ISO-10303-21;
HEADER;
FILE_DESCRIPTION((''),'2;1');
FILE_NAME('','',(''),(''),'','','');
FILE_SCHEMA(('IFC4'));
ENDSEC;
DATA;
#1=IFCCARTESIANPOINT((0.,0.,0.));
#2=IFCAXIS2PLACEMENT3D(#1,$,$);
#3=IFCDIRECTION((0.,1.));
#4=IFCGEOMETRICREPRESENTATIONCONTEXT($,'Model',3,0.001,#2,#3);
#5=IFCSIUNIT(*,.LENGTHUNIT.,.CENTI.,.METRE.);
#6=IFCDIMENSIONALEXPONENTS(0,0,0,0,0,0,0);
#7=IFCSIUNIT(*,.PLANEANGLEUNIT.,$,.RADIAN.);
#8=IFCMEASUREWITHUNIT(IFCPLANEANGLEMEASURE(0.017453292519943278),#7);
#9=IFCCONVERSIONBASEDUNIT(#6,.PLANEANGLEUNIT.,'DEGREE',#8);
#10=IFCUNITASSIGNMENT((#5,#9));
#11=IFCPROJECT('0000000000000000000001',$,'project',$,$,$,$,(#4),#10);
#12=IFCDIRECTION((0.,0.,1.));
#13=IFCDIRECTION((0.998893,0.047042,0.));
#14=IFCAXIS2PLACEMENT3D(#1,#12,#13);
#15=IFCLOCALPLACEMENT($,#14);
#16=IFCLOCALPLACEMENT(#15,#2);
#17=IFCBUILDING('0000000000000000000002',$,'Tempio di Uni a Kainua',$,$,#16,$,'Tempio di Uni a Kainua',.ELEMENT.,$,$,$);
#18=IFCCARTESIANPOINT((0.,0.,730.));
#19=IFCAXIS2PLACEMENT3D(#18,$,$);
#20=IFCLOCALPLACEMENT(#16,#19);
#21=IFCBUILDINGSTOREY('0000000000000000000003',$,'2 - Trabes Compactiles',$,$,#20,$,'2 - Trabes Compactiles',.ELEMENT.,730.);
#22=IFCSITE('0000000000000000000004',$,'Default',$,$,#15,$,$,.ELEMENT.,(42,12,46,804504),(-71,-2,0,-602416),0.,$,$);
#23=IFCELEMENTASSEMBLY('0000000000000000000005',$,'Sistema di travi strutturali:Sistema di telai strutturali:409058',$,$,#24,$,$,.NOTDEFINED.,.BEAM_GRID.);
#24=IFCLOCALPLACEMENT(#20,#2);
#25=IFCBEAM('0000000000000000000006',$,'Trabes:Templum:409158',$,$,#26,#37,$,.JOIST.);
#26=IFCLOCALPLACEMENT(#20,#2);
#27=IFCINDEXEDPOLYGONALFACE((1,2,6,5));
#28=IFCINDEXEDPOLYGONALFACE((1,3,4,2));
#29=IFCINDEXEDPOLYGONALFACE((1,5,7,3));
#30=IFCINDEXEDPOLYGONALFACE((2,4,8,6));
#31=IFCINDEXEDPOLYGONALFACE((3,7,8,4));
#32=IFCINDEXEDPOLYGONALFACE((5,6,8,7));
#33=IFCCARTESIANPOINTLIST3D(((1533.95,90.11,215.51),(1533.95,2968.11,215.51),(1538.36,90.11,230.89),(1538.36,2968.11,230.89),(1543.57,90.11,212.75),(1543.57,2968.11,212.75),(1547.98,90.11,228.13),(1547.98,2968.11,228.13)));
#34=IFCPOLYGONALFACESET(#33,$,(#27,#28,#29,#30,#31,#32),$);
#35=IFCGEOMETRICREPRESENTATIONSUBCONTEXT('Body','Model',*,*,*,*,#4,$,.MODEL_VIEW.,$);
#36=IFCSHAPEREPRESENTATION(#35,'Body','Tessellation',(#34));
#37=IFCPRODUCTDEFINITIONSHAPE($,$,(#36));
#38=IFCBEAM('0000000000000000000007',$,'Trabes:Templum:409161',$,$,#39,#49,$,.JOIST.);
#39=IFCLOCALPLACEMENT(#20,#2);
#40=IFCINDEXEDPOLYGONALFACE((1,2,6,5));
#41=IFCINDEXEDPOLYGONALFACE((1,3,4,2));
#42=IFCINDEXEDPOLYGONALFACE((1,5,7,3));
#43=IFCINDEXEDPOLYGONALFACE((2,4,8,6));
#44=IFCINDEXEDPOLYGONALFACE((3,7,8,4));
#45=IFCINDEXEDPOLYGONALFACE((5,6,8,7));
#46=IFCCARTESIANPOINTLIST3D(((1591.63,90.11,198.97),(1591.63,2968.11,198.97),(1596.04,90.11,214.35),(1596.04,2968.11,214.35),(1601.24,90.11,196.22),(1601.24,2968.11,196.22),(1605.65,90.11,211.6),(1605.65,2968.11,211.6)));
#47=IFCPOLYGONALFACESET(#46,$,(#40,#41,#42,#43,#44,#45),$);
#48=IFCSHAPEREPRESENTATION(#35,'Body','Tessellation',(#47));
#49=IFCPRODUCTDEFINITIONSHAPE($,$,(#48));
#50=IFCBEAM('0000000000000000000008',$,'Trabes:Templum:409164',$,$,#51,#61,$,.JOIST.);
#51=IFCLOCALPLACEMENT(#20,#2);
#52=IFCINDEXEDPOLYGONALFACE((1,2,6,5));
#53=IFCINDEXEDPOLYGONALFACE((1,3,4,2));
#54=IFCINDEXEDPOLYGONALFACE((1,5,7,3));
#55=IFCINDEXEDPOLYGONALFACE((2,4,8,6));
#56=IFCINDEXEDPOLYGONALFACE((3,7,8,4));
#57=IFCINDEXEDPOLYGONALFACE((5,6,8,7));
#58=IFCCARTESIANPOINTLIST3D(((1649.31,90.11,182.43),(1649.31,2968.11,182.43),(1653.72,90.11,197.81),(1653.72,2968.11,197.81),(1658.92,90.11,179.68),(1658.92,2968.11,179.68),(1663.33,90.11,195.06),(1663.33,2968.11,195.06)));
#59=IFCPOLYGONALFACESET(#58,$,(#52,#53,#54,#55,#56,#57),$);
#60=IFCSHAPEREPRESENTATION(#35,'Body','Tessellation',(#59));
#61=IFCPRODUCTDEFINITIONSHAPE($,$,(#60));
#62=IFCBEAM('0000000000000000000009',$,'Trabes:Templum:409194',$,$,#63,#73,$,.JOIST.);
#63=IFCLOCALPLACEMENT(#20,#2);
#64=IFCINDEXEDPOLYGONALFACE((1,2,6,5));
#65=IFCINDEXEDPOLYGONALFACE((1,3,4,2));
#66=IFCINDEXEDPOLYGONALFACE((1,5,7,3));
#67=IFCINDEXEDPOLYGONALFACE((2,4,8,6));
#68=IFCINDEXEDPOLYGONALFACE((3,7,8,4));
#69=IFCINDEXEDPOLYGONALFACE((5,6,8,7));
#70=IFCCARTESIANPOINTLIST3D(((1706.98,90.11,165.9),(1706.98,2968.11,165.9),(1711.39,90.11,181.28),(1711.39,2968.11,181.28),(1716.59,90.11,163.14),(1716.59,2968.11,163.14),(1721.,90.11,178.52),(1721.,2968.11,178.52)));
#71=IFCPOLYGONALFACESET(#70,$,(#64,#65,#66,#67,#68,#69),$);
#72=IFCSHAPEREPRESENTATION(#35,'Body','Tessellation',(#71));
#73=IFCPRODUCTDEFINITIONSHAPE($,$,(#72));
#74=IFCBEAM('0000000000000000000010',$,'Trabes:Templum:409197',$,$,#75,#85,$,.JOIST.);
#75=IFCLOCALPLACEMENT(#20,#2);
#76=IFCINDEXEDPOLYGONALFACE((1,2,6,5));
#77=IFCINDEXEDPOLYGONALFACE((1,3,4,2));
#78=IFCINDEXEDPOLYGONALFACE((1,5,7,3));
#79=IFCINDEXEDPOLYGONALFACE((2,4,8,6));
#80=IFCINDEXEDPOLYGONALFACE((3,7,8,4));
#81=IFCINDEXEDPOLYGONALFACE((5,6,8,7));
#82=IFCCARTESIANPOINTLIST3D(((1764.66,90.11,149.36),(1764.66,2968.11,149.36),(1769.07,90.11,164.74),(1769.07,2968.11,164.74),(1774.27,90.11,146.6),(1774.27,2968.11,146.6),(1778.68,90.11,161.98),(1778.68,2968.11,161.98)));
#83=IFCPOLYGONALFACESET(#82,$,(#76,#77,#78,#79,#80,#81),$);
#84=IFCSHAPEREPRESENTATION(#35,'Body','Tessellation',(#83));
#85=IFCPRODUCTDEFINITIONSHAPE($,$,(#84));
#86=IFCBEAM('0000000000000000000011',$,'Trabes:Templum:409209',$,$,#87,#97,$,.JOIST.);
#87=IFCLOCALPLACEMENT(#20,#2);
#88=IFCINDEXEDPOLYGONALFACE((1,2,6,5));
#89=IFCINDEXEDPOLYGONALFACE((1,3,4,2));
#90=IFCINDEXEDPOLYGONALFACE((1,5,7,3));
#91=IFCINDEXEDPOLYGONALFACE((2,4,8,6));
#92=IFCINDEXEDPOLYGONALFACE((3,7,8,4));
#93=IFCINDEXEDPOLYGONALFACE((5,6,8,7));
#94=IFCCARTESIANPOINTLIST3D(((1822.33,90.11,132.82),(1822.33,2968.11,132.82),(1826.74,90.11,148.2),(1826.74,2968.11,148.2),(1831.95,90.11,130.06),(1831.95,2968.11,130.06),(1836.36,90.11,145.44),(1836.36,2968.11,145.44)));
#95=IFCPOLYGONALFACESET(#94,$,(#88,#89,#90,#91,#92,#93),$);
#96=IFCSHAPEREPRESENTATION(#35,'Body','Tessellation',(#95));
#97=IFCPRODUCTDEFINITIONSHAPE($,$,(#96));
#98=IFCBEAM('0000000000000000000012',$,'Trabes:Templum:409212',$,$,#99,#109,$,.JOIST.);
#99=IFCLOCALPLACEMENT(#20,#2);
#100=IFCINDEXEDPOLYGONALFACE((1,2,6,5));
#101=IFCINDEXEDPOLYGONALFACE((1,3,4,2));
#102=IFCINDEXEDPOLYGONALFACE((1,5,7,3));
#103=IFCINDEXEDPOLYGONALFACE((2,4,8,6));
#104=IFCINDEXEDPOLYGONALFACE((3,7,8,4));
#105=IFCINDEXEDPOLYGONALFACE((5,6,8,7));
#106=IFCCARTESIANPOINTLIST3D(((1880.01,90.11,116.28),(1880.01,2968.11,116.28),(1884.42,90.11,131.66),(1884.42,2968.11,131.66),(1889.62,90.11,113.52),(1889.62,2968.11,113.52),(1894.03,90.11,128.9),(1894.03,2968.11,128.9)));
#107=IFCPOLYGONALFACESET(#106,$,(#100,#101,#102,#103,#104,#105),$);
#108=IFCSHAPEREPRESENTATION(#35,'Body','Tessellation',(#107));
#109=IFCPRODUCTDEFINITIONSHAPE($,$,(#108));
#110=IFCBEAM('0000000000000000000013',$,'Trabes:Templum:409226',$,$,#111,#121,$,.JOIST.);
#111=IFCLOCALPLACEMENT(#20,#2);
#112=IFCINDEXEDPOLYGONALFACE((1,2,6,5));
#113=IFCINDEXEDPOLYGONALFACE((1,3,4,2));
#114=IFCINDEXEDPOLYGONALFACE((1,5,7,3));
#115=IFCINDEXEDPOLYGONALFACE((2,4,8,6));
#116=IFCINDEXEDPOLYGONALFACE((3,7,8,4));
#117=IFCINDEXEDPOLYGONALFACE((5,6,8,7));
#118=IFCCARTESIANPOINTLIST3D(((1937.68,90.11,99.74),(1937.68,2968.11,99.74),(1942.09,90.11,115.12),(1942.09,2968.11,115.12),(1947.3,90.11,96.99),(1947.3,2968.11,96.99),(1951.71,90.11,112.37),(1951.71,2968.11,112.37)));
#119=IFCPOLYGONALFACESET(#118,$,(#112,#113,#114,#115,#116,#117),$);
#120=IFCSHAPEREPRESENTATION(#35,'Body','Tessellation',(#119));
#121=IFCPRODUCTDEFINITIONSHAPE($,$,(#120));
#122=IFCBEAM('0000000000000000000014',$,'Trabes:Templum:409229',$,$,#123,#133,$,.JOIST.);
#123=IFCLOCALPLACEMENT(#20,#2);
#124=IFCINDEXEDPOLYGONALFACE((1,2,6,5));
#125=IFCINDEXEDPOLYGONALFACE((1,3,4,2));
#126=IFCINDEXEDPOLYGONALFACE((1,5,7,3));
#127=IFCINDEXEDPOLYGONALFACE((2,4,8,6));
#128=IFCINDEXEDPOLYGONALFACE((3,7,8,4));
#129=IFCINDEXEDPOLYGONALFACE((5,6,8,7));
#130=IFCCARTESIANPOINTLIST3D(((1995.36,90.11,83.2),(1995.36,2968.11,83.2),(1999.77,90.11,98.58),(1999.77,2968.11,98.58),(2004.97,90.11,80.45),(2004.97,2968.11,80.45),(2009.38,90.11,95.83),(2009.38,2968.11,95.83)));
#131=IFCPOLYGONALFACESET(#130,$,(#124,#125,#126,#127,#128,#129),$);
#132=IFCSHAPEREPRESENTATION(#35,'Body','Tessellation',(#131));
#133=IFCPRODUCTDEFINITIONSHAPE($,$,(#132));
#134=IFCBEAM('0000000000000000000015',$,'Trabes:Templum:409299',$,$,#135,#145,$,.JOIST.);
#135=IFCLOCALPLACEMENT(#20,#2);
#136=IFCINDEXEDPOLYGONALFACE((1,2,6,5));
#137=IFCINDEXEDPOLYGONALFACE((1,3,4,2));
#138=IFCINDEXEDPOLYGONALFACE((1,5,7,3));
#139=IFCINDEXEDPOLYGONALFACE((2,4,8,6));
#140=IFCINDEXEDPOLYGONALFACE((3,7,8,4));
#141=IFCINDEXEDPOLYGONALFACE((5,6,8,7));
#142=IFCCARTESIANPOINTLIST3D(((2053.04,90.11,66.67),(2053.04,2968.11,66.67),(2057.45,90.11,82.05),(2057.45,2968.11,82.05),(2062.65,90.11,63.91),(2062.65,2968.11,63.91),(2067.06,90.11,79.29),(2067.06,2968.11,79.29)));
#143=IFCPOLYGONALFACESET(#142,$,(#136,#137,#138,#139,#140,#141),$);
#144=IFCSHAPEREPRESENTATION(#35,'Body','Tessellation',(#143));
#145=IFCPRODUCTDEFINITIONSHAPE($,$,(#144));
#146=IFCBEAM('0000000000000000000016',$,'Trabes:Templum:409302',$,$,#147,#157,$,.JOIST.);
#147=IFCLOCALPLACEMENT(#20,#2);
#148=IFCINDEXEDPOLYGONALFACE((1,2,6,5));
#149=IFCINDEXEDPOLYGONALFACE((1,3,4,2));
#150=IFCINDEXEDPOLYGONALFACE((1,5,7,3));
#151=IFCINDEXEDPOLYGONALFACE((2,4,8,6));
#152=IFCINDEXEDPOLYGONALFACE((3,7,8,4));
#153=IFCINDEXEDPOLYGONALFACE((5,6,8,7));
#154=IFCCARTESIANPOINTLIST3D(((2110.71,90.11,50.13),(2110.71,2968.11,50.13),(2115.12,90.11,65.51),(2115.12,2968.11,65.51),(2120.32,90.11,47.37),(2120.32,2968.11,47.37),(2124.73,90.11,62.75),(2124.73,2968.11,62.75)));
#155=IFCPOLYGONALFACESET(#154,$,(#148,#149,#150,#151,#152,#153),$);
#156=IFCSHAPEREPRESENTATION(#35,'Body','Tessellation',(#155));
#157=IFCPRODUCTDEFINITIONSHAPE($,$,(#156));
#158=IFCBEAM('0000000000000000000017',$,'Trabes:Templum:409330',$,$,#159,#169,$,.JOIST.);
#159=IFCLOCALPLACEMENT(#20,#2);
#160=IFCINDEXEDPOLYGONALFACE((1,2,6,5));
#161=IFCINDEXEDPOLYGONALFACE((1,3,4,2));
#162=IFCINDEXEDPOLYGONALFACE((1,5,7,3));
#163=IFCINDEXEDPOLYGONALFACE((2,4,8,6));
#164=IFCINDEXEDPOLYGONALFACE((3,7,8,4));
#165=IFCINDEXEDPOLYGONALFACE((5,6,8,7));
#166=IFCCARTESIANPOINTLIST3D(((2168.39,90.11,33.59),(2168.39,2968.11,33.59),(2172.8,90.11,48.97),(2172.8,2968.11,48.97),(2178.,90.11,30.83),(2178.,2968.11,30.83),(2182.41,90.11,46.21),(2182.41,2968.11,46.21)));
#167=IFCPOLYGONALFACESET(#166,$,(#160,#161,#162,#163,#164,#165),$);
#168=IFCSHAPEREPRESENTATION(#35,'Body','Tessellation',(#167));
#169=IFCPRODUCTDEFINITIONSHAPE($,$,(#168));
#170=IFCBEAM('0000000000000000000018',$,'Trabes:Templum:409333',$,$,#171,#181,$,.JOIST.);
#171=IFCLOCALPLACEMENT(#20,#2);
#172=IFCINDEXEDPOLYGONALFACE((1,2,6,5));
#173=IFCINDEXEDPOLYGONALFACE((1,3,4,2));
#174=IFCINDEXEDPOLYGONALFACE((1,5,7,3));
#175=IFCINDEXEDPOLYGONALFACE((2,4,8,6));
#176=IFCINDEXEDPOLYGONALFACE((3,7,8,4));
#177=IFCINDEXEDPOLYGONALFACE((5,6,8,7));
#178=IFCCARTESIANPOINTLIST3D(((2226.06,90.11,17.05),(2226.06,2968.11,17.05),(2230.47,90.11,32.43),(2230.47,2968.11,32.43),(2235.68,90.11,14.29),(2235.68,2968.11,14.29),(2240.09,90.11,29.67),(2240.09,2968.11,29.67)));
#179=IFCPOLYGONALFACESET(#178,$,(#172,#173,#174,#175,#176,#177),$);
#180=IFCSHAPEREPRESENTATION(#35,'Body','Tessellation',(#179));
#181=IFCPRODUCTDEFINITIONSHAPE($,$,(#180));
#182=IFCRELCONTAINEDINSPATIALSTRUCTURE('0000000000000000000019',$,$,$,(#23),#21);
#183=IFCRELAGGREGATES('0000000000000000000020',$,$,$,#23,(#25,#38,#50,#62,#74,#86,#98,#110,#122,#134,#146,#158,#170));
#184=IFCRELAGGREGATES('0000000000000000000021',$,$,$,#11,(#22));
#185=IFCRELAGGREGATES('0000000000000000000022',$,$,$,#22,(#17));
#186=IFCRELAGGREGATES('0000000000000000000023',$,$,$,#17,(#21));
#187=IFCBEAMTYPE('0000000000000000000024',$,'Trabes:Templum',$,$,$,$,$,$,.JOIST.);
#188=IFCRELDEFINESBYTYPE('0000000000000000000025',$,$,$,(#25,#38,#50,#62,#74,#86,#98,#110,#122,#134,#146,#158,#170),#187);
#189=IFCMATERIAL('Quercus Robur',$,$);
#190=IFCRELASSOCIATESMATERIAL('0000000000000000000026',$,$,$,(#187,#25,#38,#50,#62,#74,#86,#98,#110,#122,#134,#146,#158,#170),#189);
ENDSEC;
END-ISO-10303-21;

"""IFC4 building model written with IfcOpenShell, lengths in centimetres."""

from ifc_helpers import new_model, entity, si_unit, converted_unit, direction, frame, frame_2d, origin, origin_2d_with_axis, place, context, subcontext, project, spatial, rectangle, extrude, source, transform, mapped, material, material_profile, profile_set, profile_usage, type_object, type_shapes, element, aggregate, save


model = new_model("IFC4")

# Units and contexts
model_context = context("Model", 3, precision=0.001, world=origin(), true_north=direction((0.0, 1.0)))
body_context = subcontext(model_context, "Body", "Model", "MODEL_VIEW")
ifc_project = project(units=[si_unit("LENGTHUNIT", "METRE", prefix="CENTI"), converted_unit("PLANEANGLEUNIT", "DEGREE", entity("IfcPlaneAngleMeasure", 0.017453292519943278), si_unit("PLANEANGLEUNIT", "RADIAN"), dimensions=[0, 0, 0, 0, 0, 0, 0])], contexts=[model_context])

# Site, building, storey
site_placement = place(None, frame((0.0, 0.0, 0.0), z_axis=(0.0, 0.0, 1.0), x_axis=(0.998893, 0.047042, 0.0)))
site = spatial("IfcSite", under=ifc_project, at=site_placement, Name="Default", CompositionType="ELEMENT", RefLatitude=(42, 12, 46, 804504), RefLongitude=(-71, -2, 0, -602416), RefElevation=0.0)
building_placement = place(site_placement, origin())
building = spatial("IfcBuilding", under=site, at=building_placement, Name="Tempio di Uni a Kainua", LongName="Tempio di Uni a Kainua", CompositionType="ELEMENT")
storey_placement = place(building_placement, frame((0.0, 0.0, 730.0)))
storey = spatial("IfcBuildingStorey", under=building, at=storey_placement, Name="2 - Trabes Compactiles", LongName="2 - Trabes Compactiles", CompositionType="ELEMENT", Elevation=730.0)

# Element assembly, beams
ifc_material = material(Name="Quercus Robur")
assembly_1_placement = place(storey_placement, origin())
assembly_1 = element("IfcElementAssembly", 1, at=assembly_1_placement, inside=storey, Name="Sistema di travi strutturali:Sistema di telai strutturali:409058", AssemblyPlace="NOTDEFINED", PredefinedType="BEAM_GRID")
ifc_material_profile_1 = material_profile(ifc_material, rectangle(XDim=2875.46, YDim=10.0, at=origin_2d_with_axis()), Name="Templum")
ifc_profile_set_1 = profile_set([ifc_material_profile_1], Name="Templum")
ifc_profile_usage_1 = profile_usage(ifc_profile_set_1, cardinal=2)
beam_type_1 = type_object("IfcBeamType", Name="Trabes:Templum", PredefinedType="JOIST", material=ifc_profile_set_1)
shared_shape_1 = source(origin(), body_context, "Body", "SweptSolid", [
    extrude(rectangle(XDim=2878.0, YDim=10.0, at=frame_2d((0.0, 0.0), x_axis=(1.0, 0.0))), frame((0.0, 0.0, -8.0)), (0.0, 0.0, 1.0), 16.0),
])
type_shapes(beam_type_1, [shared_shape_1])
beam_1_placement = place(assembly_1_placement, frame((1540.97, 1529.11, 221.82), z_axis=(0.275637, 0.0, 0.961262), x_axis=(0.0, 1.0, 0.0)))
beam_1 = element("IfcBeam", 2, at=beam_1_placement, type_object=beam_type_1, material=ifc_profile_usage_1, Name="Trabes:Templum:409158", PredefinedType="JOIST", context=body_context, shape_type="MappedRepresentation", body=[
    mapped(shared_shape_1, transform((0.0, 0.0, 0.0), scale=1.0)),
])
beam_2_placement = place(assembly_1_placement, frame((1598.64, 1529.11, 205.28), z_axis=(0.275637, 0.0, 0.961262), x_axis=(0.0, 1.0, 0.0)))
beam_2 = element("IfcBeam", 3, at=beam_2_placement, type_object=beam_type_1, material=ifc_profile_usage_1, Name="Trabes:Templum:409161", PredefinedType="JOIST", context=body_context, shape_type="MappedRepresentation", body=[
    mapped(shared_shape_1, transform((0.0, 0.0, 0.0), scale=1.0)),
])
beam_3_placement = place(assembly_1_placement, frame((1656.32, 1529.11, 188.75), z_axis=(0.275637, 0.0, 0.961262), x_axis=(0.0, 1.0, 0.0)))
beam_3 = element("IfcBeam", 4, at=beam_3_placement, type_object=beam_type_1, material=ifc_profile_usage_1, Name="Trabes:Templum:409164", PredefinedType="JOIST", context=body_context, shape_type="MappedRepresentation", body=[
    mapped(shared_shape_1, transform((0.0, 0.0, 0.0), scale=1.0)),
])
beam_4_placement = place(assembly_1_placement, frame((1713.99, 1529.11, 172.21), z_axis=(0.275637, 0.0, 0.961262), x_axis=(0.0, 1.0, 0.0)))
beam_4 = element("IfcBeam", 5, at=beam_4_placement, type_object=beam_type_1, material=ifc_profile_usage_1, Name="Trabes:Templum:409194", PredefinedType="JOIST", context=body_context, shape_type="MappedRepresentation", body=[
    mapped(shared_shape_1, transform((0.0, 0.0, 0.0), scale=1.0)),
])
beam_5_placement = place(assembly_1_placement, frame((1771.67, 1529.11, 155.67), z_axis=(0.275637, 0.0, 0.961262), x_axis=(0.0, 1.0, 0.0)))
beam_5 = element("IfcBeam", 6, at=beam_5_placement, type_object=beam_type_1, material=ifc_profile_usage_1, Name="Trabes:Templum:409197", PredefinedType="JOIST", context=body_context, shape_type="MappedRepresentation", body=[
    mapped(shared_shape_1, transform((0.0, 0.0, 0.0), scale=1.0)),
])
beam_6_placement = place(assembly_1_placement, frame((1829.34, 1529.11, 139.13), z_axis=(0.275637, 0.0, 0.961262), x_axis=(0.0, 1.0, 0.0)))
beam_6 = element("IfcBeam", 7, at=beam_6_placement, type_object=beam_type_1, material=ifc_profile_usage_1, Name="Trabes:Templum:409209", PredefinedType="JOIST", context=body_context, shape_type="MappedRepresentation", body=[
    mapped(shared_shape_1, transform((0.0, 0.0, 0.0), scale=1.0)),
])
beam_7_placement = place(assembly_1_placement, frame((1887.02, 1529.11, 122.59), z_axis=(0.275637, 0.0, 0.961262), x_axis=(0.0, 1.0, 0.0)))
beam_7 = element("IfcBeam", 8, at=beam_7_placement, type_object=beam_type_1, material=ifc_profile_usage_1, Name="Trabes:Templum:409212", PredefinedType="JOIST", context=body_context, shape_type="MappedRepresentation", body=[
    mapped(shared_shape_1, transform((0.0, 0.0, 0.0), scale=1.0)),
])
beam_8_placement = place(assembly_1_placement, frame((1944.7, 1529.11, 106.05), z_axis=(0.275637, 0.0, 0.961262), x_axis=(0.0, 1.0, 0.0)))
beam_8 = element("IfcBeam", 9, at=beam_8_placement, type_object=beam_type_1, material=ifc_profile_usage_1, Name="Trabes:Templum:409226", PredefinedType="JOIST", context=body_context, shape_type="MappedRepresentation", body=[
    mapped(shared_shape_1, transform((0.0, 0.0, 0.0), scale=1.0)),
])
beam_9_placement = place(assembly_1_placement, frame((2002.37, 1529.11, 89.52), z_axis=(0.275637, 0.0, 0.961262), x_axis=(0.0, 1.0, 0.0)))
beam_9 = element("IfcBeam", 10, at=beam_9_placement, type_object=beam_type_1, material=ifc_profile_usage_1, Name="Trabes:Templum:409229", PredefinedType="JOIST", context=body_context, shape_type="MappedRepresentation", body=[
    mapped(shared_shape_1, transform((0.0, 0.0, 0.0), scale=1.0)),
])
beam_10_placement = place(assembly_1_placement, frame((2060.05, 1529.11, 72.98), z_axis=(0.275637, 0.0, 0.961262), x_axis=(0.0, 1.0, 0.0)))
beam_10 = element("IfcBeam", 11, at=beam_10_placement, type_object=beam_type_1, material=ifc_profile_usage_1, Name="Trabes:Templum:409299", PredefinedType="JOIST", context=body_context, shape_type="MappedRepresentation", body=[
    mapped(shared_shape_1, transform((0.0, 0.0, 0.0), scale=1.0)),
])
beam_11_placement = place(assembly_1_placement, frame((2117.72, 1529.11, 56.44), z_axis=(0.275637, 0.0, 0.961262), x_axis=(0.0, 1.0, 0.0)))
beam_11 = element("IfcBeam", 12, at=beam_11_placement, type_object=beam_type_1, material=ifc_profile_usage_1, Name="Trabes:Templum:409302", PredefinedType="JOIST", context=body_context, shape_type="MappedRepresentation", body=[
    mapped(shared_shape_1, transform((0.0, 0.0, 0.0), scale=1.0)),
])
beam_12_placement = place(assembly_1_placement, frame((2175.4, 1529.11, 39.9), z_axis=(0.275637, 0.0, 0.961262), x_axis=(0.0, 1.0, 0.0)))
beam_12 = element("IfcBeam", 13, at=beam_12_placement, type_object=beam_type_1, material=ifc_profile_usage_1, Name="Trabes:Templum:409330", PredefinedType="JOIST", context=body_context, shape_type="MappedRepresentation", body=[
    mapped(shared_shape_1, transform((0.0, 0.0, 0.0), scale=1.0)),
])
beam_13_placement = place(assembly_1_placement, frame((2233.07, 1529.11, 23.36), z_axis=(0.275637, 0.0, 0.961262), x_axis=(0.0, 1.0, 0.0)))
beam_13 = element("IfcBeam", 14, at=beam_13_placement, type_object=beam_type_1, material=ifc_profile_usage_1, Name="Trabes:Templum:409333", PredefinedType="JOIST", context=body_context, shape_type="MappedRepresentation", body=[
    mapped(shared_shape_1, transform((0.0, 0.0, 0.0), scale=1.0)),
])
aggregate(assembly_1, [beam_1, beam_2, beam_3, beam_4, beam_5, beam_6, beam_7, beam_8, beam_9, beam_10, beam_11, beam_12, beam_13])

save(model, "model.ifc")
